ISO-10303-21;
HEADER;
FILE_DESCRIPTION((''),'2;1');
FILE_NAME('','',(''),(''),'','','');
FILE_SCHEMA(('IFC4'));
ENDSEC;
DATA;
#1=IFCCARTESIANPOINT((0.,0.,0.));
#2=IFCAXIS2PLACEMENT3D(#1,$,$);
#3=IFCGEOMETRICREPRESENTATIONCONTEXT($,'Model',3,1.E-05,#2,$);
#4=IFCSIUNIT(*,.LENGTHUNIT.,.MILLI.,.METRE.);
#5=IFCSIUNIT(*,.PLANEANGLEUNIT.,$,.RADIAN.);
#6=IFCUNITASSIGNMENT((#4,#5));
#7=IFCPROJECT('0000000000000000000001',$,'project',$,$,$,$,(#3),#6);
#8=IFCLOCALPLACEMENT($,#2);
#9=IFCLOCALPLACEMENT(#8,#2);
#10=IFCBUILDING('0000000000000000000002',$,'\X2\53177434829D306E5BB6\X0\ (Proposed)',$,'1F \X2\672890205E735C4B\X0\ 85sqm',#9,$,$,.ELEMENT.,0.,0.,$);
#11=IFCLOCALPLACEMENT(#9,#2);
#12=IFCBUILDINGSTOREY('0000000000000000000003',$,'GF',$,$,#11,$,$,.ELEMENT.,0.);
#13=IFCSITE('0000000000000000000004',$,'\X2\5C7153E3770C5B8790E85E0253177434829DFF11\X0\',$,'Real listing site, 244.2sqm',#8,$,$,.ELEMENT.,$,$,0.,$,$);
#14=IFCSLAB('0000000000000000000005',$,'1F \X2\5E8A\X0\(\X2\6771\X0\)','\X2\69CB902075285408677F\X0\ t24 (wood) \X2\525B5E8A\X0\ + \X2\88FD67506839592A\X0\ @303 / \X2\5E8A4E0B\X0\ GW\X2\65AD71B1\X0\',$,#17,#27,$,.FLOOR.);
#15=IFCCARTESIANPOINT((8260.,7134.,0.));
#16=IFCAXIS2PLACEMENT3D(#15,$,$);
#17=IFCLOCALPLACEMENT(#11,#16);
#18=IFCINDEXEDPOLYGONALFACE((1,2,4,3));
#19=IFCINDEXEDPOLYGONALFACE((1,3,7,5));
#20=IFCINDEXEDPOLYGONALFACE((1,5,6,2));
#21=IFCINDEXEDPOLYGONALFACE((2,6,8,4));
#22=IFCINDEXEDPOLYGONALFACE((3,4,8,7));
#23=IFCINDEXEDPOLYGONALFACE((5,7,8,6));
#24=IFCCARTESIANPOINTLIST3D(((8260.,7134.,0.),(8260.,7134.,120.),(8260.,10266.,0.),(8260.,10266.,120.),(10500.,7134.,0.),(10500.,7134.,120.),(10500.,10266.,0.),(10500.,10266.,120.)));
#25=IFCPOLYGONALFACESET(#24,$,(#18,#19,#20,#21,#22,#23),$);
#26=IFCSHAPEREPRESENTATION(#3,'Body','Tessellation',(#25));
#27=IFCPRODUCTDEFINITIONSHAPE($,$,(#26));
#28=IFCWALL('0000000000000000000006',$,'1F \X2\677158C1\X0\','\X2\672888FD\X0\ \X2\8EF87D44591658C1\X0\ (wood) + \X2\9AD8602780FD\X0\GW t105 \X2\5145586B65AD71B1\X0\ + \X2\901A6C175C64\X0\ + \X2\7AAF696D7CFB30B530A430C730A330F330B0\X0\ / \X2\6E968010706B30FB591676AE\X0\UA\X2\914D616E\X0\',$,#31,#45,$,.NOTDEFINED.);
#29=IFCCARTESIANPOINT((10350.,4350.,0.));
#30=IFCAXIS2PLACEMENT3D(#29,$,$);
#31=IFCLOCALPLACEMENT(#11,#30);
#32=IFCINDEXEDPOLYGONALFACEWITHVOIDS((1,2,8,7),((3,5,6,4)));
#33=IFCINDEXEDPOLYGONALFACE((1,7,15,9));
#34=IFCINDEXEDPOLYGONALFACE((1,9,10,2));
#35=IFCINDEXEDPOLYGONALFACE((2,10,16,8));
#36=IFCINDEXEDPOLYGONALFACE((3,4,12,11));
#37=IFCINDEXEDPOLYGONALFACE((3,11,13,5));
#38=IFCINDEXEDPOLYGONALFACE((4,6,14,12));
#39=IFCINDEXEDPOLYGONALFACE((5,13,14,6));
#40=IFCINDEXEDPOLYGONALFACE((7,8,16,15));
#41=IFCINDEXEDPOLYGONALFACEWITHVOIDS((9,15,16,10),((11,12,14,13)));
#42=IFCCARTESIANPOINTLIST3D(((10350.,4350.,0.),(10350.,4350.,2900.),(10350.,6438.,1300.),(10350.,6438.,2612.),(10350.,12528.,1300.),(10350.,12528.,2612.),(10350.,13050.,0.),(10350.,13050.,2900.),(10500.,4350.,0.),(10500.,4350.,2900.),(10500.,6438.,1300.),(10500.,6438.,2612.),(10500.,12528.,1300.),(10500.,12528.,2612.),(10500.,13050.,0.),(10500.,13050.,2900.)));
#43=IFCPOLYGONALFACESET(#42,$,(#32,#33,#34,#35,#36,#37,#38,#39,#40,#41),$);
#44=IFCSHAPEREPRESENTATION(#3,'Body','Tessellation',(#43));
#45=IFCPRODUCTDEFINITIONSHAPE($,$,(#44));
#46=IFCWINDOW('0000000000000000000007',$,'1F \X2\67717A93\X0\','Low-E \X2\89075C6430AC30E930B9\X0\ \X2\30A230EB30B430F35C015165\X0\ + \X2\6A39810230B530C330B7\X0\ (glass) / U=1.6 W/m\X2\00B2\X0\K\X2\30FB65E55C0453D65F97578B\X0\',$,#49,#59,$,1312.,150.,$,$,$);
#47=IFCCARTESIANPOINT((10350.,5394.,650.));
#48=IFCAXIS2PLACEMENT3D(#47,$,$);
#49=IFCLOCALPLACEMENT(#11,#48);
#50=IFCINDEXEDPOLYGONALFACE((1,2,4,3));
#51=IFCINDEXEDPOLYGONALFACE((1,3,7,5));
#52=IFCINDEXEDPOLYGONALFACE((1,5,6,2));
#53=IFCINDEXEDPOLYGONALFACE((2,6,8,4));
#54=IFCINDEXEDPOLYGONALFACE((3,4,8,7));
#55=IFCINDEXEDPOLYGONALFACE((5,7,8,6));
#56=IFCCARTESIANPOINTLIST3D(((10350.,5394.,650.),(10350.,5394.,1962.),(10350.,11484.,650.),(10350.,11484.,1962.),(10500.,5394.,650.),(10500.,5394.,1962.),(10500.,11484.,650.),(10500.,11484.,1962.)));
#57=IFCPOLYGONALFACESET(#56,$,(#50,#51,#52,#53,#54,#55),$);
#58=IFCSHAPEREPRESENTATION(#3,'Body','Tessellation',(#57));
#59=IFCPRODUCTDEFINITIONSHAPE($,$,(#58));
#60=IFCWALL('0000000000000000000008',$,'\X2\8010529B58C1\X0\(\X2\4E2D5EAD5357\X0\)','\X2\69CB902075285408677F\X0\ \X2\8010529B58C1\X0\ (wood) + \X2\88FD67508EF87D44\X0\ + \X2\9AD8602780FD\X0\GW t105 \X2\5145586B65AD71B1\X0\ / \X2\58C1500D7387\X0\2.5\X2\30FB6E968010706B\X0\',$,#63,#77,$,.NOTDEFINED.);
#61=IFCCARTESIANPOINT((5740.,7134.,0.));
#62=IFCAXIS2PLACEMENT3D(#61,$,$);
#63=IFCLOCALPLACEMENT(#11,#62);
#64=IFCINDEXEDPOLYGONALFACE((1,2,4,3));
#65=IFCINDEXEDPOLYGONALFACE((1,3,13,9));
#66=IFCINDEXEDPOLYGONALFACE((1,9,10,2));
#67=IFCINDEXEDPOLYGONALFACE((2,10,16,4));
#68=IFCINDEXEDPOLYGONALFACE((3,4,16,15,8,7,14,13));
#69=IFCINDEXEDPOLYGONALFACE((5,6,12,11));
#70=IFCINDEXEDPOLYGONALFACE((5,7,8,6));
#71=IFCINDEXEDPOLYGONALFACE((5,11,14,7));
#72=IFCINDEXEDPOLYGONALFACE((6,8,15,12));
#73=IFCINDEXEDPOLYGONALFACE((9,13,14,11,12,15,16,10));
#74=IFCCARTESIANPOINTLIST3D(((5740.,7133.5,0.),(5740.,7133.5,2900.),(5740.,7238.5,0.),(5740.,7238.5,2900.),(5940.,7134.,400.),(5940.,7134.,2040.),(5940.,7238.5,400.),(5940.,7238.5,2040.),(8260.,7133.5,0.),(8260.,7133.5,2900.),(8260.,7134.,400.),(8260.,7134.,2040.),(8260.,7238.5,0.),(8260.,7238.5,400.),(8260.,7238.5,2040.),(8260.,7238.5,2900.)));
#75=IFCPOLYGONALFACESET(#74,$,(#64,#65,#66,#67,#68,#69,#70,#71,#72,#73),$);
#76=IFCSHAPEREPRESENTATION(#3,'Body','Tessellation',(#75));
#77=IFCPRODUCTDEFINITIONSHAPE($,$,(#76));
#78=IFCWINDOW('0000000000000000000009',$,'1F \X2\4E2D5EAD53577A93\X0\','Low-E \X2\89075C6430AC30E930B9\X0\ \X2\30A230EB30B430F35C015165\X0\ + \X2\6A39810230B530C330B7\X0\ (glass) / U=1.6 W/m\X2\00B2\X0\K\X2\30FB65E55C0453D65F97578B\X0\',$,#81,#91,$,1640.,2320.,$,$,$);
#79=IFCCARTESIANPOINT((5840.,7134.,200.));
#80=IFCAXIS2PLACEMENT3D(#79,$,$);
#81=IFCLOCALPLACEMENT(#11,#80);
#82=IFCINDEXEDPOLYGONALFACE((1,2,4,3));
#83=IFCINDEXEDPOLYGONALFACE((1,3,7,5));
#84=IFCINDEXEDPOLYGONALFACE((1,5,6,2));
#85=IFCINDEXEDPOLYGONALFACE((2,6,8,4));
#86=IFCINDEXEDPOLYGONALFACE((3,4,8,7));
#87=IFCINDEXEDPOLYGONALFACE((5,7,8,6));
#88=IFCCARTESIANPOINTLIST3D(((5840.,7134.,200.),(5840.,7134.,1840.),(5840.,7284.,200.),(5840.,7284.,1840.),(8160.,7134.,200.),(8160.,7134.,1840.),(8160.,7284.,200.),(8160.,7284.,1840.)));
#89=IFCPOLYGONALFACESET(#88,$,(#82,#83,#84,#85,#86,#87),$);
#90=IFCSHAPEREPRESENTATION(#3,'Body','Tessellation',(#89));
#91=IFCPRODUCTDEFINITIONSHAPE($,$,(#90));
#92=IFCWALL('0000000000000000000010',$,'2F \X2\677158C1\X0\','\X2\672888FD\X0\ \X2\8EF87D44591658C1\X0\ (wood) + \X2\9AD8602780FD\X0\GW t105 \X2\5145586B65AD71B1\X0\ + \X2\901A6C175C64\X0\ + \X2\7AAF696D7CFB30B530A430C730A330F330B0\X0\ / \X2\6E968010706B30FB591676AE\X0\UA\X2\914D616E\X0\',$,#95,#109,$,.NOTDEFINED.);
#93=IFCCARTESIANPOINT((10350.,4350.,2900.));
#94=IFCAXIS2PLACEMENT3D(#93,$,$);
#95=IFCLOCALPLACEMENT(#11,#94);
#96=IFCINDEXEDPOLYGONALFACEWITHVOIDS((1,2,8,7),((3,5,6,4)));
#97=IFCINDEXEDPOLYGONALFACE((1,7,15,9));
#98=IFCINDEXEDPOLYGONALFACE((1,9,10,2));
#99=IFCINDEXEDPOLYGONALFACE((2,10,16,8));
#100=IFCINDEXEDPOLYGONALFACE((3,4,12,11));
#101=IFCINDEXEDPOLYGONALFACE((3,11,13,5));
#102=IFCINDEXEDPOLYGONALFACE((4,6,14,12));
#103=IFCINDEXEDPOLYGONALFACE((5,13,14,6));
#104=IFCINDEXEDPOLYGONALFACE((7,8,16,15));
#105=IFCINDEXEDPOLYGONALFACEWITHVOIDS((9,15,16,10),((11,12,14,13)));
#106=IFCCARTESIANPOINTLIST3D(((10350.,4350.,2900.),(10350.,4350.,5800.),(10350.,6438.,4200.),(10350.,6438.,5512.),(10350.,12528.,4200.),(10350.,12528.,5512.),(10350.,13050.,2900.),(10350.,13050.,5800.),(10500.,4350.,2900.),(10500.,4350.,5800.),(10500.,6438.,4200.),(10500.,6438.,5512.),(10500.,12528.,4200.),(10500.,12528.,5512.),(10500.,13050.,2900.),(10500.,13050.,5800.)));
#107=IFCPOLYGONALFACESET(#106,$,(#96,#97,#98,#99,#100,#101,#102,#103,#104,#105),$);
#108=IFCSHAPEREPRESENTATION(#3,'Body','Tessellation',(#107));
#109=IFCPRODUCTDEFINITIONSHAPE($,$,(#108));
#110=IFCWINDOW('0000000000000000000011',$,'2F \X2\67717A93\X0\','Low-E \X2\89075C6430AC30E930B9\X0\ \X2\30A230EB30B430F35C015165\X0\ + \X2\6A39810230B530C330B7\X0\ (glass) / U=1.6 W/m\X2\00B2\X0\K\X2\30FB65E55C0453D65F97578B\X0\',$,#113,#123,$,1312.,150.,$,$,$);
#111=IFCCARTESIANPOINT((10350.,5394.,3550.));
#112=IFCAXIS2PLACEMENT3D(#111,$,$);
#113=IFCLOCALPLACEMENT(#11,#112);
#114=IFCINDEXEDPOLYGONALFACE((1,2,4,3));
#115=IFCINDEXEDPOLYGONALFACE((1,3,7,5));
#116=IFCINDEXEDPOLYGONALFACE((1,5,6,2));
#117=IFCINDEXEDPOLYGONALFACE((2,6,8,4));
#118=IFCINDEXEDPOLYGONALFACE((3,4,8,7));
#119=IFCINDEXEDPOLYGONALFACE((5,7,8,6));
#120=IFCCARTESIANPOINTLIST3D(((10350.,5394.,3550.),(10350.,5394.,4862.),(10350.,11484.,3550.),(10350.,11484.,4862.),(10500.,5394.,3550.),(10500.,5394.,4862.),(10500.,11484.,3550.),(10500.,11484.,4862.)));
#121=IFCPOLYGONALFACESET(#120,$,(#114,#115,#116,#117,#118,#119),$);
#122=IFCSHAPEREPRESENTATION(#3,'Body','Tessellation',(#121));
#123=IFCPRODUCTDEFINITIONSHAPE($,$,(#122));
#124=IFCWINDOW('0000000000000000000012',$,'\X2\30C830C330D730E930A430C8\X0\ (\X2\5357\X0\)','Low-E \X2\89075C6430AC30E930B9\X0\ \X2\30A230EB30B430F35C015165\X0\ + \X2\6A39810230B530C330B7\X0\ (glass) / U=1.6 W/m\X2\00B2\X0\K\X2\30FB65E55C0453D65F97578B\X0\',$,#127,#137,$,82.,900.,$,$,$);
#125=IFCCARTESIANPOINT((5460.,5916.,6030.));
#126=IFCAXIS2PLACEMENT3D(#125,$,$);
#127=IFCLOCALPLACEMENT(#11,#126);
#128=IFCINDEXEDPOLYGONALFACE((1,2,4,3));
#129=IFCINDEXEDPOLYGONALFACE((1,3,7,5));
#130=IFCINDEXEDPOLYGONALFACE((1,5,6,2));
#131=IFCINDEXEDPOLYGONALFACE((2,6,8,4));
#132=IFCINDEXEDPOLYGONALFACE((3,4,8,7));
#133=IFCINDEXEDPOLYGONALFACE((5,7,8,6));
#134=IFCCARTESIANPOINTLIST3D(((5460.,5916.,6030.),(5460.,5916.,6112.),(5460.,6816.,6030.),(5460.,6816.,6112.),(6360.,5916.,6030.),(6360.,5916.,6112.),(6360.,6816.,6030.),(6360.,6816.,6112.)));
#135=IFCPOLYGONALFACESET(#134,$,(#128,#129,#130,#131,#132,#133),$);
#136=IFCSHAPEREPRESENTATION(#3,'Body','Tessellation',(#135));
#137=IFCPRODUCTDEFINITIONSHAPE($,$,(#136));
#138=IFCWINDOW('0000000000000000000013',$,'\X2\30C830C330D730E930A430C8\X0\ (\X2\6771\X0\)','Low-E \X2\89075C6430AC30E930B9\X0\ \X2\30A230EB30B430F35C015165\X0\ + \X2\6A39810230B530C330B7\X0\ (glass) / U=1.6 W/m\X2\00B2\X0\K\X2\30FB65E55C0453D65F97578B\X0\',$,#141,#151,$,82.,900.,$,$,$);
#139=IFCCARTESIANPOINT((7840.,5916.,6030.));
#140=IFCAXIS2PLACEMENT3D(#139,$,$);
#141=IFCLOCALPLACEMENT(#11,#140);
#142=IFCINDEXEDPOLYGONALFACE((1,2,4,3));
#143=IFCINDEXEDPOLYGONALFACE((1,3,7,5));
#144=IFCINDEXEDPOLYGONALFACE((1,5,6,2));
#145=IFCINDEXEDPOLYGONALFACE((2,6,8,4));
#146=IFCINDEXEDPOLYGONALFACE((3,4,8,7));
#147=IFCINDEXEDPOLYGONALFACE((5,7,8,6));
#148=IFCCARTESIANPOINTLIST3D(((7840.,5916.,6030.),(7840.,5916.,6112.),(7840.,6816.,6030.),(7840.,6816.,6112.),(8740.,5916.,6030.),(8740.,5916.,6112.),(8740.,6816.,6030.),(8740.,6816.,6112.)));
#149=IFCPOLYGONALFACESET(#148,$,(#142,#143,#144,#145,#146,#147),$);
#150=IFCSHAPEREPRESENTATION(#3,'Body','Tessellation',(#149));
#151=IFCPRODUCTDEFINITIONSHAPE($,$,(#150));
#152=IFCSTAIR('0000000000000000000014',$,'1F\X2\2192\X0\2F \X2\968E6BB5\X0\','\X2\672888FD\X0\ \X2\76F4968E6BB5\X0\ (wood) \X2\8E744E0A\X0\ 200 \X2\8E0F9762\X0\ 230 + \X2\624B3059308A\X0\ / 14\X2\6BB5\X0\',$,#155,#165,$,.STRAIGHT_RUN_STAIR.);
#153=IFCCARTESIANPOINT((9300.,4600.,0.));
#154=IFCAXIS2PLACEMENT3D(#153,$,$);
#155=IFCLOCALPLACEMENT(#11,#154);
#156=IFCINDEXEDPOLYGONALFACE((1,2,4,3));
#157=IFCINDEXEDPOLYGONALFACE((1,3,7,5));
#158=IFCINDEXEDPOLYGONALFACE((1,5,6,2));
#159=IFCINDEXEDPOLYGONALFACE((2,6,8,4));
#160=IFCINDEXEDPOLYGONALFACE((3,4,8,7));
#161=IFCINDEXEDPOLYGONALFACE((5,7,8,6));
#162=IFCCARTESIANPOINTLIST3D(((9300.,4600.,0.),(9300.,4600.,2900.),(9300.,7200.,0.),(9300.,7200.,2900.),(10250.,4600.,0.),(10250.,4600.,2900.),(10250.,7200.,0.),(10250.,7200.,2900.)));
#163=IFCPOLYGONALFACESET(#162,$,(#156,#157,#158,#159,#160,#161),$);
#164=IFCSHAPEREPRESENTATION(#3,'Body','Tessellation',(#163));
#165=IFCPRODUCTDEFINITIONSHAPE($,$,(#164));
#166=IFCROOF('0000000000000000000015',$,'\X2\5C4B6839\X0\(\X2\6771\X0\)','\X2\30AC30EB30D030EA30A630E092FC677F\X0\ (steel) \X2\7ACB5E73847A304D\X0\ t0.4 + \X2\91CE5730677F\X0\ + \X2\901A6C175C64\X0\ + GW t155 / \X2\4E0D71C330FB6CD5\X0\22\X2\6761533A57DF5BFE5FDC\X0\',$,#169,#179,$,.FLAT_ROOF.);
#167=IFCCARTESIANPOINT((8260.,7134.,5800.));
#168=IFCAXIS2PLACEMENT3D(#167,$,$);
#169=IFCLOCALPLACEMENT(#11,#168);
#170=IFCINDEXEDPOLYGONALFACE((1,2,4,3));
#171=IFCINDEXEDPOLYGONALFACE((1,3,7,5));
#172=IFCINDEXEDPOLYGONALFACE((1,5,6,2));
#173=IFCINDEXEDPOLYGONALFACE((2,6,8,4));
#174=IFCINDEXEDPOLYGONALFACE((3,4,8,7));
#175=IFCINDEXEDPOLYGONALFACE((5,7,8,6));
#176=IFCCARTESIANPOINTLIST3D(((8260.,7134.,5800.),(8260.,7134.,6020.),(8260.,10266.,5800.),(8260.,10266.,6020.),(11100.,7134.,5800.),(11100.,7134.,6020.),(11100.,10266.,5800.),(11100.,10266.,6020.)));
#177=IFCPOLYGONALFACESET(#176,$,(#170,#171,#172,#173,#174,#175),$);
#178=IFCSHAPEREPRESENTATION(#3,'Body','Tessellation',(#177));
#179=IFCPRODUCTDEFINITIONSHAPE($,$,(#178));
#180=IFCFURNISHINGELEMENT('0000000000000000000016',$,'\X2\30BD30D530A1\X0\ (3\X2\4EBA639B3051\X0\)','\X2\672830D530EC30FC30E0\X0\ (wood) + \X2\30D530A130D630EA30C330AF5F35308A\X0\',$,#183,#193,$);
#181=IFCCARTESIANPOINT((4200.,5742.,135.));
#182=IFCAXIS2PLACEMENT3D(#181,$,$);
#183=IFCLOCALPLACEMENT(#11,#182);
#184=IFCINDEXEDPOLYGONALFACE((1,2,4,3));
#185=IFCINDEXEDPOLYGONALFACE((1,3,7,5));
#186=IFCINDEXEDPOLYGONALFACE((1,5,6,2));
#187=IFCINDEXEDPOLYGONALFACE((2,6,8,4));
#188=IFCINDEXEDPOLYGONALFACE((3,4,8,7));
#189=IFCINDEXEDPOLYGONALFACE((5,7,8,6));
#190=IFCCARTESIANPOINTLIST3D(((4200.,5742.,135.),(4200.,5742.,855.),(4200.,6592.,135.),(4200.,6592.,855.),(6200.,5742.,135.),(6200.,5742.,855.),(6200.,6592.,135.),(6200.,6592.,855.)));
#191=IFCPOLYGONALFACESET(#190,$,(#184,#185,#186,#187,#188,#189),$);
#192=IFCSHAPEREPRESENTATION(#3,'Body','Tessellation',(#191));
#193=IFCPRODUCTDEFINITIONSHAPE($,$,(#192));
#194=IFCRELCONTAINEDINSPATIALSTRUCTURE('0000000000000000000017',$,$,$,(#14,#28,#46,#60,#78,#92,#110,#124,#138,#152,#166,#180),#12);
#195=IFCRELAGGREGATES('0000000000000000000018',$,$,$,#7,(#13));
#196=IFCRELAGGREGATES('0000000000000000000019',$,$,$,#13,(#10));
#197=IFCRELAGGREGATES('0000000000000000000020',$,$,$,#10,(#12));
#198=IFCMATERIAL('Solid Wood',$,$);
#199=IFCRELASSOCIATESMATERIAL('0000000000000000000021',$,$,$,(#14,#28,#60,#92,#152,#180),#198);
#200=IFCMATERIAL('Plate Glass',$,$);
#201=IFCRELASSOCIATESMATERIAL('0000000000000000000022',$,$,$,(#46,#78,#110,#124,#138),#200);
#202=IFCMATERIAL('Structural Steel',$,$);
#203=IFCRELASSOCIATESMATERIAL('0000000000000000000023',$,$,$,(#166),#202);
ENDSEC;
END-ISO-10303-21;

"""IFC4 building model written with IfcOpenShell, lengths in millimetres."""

from ifc_helpers import new_model, si_unit, frame, frame_2d, origin, place, context, project, spatial, rectangle, extrude, material, element, fill, save


model = new_model("IFC4")

# Units and contexts
model_context = context("Model", 3, precision=1e-05, world=origin())
ifc_project = project(units=[si_unit("LENGTHUNIT", "METRE", prefix="MILLI"), si_unit("PLANEANGLEUNIT", "RADIAN")], contexts=[model_context])

# Site, building, storey
site_placement = place(None, origin())
site = spatial("IfcSite", under=ifc_project, at=site_placement, Name="山口県宇部市北琴芝１", ObjectType="Real listing site, 244.2sqm", CompositionType="ELEMENT", RefElevation=0.0)
building_placement = place(site_placement, origin())
building = spatial("IfcBuilding", under=site, at=building_placement, Name="北琴芝の家 (Proposed)", ObjectType="1F 木造平屋 85sqm", CompositionType="ELEMENT", ElevationOfRefHeight=0.0, ElevationOfTerrain=0.0)
storey_placement = place(building_placement, origin())
storey = spatial("IfcBuildingStorey", under=building, at=storey_placement, Name="GF", CompositionType="ELEMENT", Elevation=0.0)

# Slab
ifc_material_1 = material(Name="Solid Wood")
slab_placement = place(storey_placement, frame((8260.0, 7134.0, 0.0)))
element("IfcSlab", 1, at=slab_placement, inside=storey, material=ifc_material_1, Name="1F 床(東)", Description="構造用合板 t24 (wood) 剛床 + 製材根太 @303 / 床下 GW断熱", PredefinedType="FLOOR", context=model_context, shape_type="SweptSolid", body=[
    extrude(rectangle(XDim=2240.0, YDim=3132.0, at=frame_2d((1120.0, 1566.0))), frame((8260.0, 7134.0, 0.0)), (0.0, 0.0, 1.0), 120.0),
])

# Walls, openings, windows
wall_1_placement = place(storey_placement, frame((10350.0, 4350.0, 0.0)))
wall_1 = element("IfcWall", 2, at=wall_1_placement, inside=storey, material=ifc_material_1, Name="1F 東壁", Description="木製 軸組外壁 (wood) + 高性能GW t105 充填断熱 + 通気層 + 窯業系サイディング / 準耐火・外皮UA配慮", PredefinedType="NOTDEFINED", context=model_context, shape_type="SweptSolid", body=[
    extrude(rectangle(XDim=150.0, YDim=8700.0, at=frame_2d((75.0, 4350.0))), frame((10350.0, 4350.0, 0.0)), (0.0, 0.0, 1.0), 2900.0),
])
opening_1_placement = place(storey_placement, frame((10350.0, 5394.0, 650.0)))
opening_1 = element("IfcOpeningElement", 3, at=opening_1_placement, cuts=wall_1, PredefinedType="NOTDEFINED", context=model_context, shape_type="SweptSolid", body=[
    extrude(rectangle(XDim=150.0, YDim=6090.0, at=frame_2d((75.0, 3045.0))), frame((10350.0, 5394.0, 650.0)), (0.0, 0.0, 1.0), 1312.0),
])
ifc_material_2 = material(Name="Plate Glass")
window_1_placement = place(storey_placement, frame((10350.0, 5394.0, 650.0)))
window_1 = element("IfcWindow", 4, at=window_1_placement, inside=storey, material=ifc_material_2, Name="1F 東窓", Description="Low-E 複層ガラス アルゴン封入 + 樹脂サッシ (glass) / U=1.6 W/m²K・日射取得型", OverallHeight=1312.0, OverallWidth=150.0, context=model_context, shape_type="SweptSolid", body=[
    extrude(rectangle(XDim=150.0, YDim=6090.0, at=frame_2d((75.0, 3045.0))), frame((10350.0, 5394.0, 650.0)), (0.0, 0.0, 1.0), 1312.0),
])
fill(opening_1, window_1)
wall_2_placement = place(storey_placement, frame((5740.0, 7134.0, 0.0)))
wall_2 = element("IfcWall", 5, at=wall_2_placement, inside=storey, material=ifc_material_1, Name="耐力壁(中庭南)", Description="構造用合板 耐力壁 (wood) + 製材軸組 + 高性能GW t105 充填断熱 / 壁倍率2.5・準耐火", PredefinedType="NOTDEFINED", context=model_context, shape_type="SweptSolid", body=[
    extrude(rectangle(XDim=2520.0, YDim=105.0, at=frame_2d((1260.0, 52.0))), frame((5740.0, 7134.0, 0.0)), (0.0, 0.0, 1.0), 2900.0),
])
opening_2_placement = place(storey_placement, frame((5840.0, 7134.0, 200.0)))
opening_2 = element("IfcOpeningElement", 6, at=opening_2_placement, cuts=wall_2, PredefinedType="NOTDEFINED", context=model_context, shape_type="SweptSolid", body=[
    extrude(rectangle(XDim=2320.0, YDim=150.0, at=frame_2d((1160.0, 75.0))), frame((5840.0, 7134.0, 200.0)), (0.0, 0.0, 1.0), 1640.0),
])
window_2_placement = place(storey_placement, frame((5840.0, 7134.0, 200.0)))
window_2 = element("IfcWindow", 7, at=window_2_placement, inside=storey, material=ifc_material_2, Name="1F 中庭南窓", Description="Low-E 複層ガラス アルゴン封入 + 樹脂サッシ (glass) / U=1.6 W/m²K・日射取得型", OverallHeight=1640.0, OverallWidth=2320.0, context=model_context, shape_type="SweptSolid", body=[
    extrude(rectangle(XDim=2320.0, YDim=150.0, at=frame_2d((1160.0, 75.0))), frame((5840.0, 7134.0, 200.0)), (0.0, 0.0, 1.0), 1640.0),
])
fill(opening_2, window_2)

# Wall, opening, window
wall_3_placement = place(storey_placement, frame((10350.0, 4350.0, 2900.0)))
wall_3 = element("IfcWall", 8, at=wall_3_placement, inside=storey, material=ifc_material_1, Name="2F 東壁", Description="木製 軸組外壁 (wood) + 高性能GW t105 充填断熱 + 通気層 + 窯業系サイディング / 準耐火・外皮UA配慮", PredefinedType="NOTDEFINED", context=model_context, shape_type="SweptSolid", body=[
    extrude(rectangle(XDim=150.0, YDim=8700.0, at=frame_2d((75.0, 4350.0))), frame((10350.0, 4350.0, 2900.0)), (0.0, 0.0, 1.0), 2900.0),
])
opening_3_placement = place(storey_placement, frame((10350.0, 5394.0, 3550.0)))
opening_3 = element("IfcOpeningElement", 9, at=opening_3_placement, cuts=wall_3, PredefinedType="NOTDEFINED", context=model_context, shape_type="SweptSolid", body=[
    extrude(rectangle(XDim=150.0, YDim=6090.0, at=frame_2d((75.0, 3045.0))), frame((10350.0, 5394.0, 3550.0)), (0.0, 0.0, 1.0), 1312.0),
])
window_3_placement = place(storey_placement, frame((10350.0, 5394.0, 3550.0)))
window_3 = element("IfcWindow", 10, at=window_3_placement, inside=storey, material=ifc_material_2, Name="2F 東窓", Description="Low-E 複層ガラス アルゴン封入 + 樹脂サッシ (glass) / U=1.6 W/m²K・日射取得型", OverallHeight=1312.0, OverallWidth=150.0, context=model_context, shape_type="SweptSolid", body=[
    extrude(rectangle(XDim=150.0, YDim=6090.0, at=frame_2d((75.0, 3045.0))), frame((10350.0, 5394.0, 3550.0)), (0.0, 0.0, 1.0), 1312.0),
])
fill(opening_3, window_3)

# Windows
window_4_placement = place(storey_placement, frame((5460.0, 5916.0, 6030.0)))
element("IfcWindow", 11, at=window_4_placement, inside=storey, material=ifc_material_2, Name="トップライト (南)", Description="Low-E 複層ガラス アルゴン封入 + 樹脂サッシ (glass) / U=1.6 W/m²K・日射取得型", OverallHeight=82.0, OverallWidth=900.0, context=model_context, shape_type="SweptSolid", body=[
    extrude(rectangle(XDim=900.0, YDim=900.0, at=frame_2d((450.0, 450.0))), frame((5460.0, 5916.0, 6030.0)), (0.0, 0.0, 1.0), 82.0),
])
window_5_placement = place(storey_placement, frame((7840.0, 5916.0, 6030.0)))
element("IfcWindow", 12, at=window_5_placement, inside=storey, material=ifc_material_2, Name="トップライト (東)", Description="Low-E 複層ガラス アルゴン封入 + 樹脂サッシ (glass) / U=1.6 W/m²K・日射取得型", OverallHeight=82.0, OverallWidth=900.0, context=model_context, shape_type="SweptSolid", body=[
    extrude(rectangle(XDim=900.0, YDim=900.0, at=frame_2d((450.0, 450.0))), frame((7840.0, 5916.0, 6030.0)), (0.0, 0.0, 1.0), 82.0),
])

# Stair
stair_placement = place(storey_placement, frame((9300.0, 4600.0, 0.0)))
element("IfcStair", 13, at=stair_placement, inside=storey, material=ifc_material_1, Name="1F→2F 階段", Description="木製 直階段 (wood) 蹴上 200 踏面 230 + 手すり / 14段", PredefinedType="STRAIGHT_RUN_STAIR", context=model_context, shape_type="SweptSolid", body=[
    extrude(rectangle(XDim=950.0, YDim=2600.0, at=frame_2d((475.0, 1300.0))), frame((9300.0, 4600.0, 0.0)), (0.0, 0.0, 1.0), 2900.0),
])

# Roof
ifc_material_3 = material(Name="Structural Steel")
roof_placement = place(storey_placement, frame((8260.0, 7134.0, 5800.0)))
element("IfcRoof", 14, at=roof_placement, inside=storey, material=ifc_material_3, Name="屋根(東)", Description="ガルバリウム鋼板 (steel) 立平葺き t0.4 + 野地板 + 通気層 + GW t155 / 不燃・法22条区域対応", PredefinedType="FLAT_ROOF", context=model_context, shape_type="SweptSolid", body=[
    extrude(rectangle(XDim=2840.0, YDim=3132.0, at=frame_2d((1420.0, 1566.0))), frame((8260.0, 7134.0, 5800.0)), (0.0, 0.0, 1.0), 220.0),
])

# Furnishing element
furnishing_1_placement = place(storey_placement, frame((4200.0, 5742.0, 135.0)))
element("IfcFurnishingElement", 15, at=furnishing_1_placement, inside=storey, material=ifc_material_1, Name="ソファ (3人掛け)", Description="木フレーム (wood) + ファブリック張り", context=model_context, shape_type="SweptSolid", body=[
    extrude(rectangle(XDim=2000.0, YDim=850.0, at=frame_2d((1000.0, 425.0))), frame((4200.0, 5742.0, 135.0)), (0.0, 0.0, 1.0), 720.0),
])

save(model, "model.ifc")
